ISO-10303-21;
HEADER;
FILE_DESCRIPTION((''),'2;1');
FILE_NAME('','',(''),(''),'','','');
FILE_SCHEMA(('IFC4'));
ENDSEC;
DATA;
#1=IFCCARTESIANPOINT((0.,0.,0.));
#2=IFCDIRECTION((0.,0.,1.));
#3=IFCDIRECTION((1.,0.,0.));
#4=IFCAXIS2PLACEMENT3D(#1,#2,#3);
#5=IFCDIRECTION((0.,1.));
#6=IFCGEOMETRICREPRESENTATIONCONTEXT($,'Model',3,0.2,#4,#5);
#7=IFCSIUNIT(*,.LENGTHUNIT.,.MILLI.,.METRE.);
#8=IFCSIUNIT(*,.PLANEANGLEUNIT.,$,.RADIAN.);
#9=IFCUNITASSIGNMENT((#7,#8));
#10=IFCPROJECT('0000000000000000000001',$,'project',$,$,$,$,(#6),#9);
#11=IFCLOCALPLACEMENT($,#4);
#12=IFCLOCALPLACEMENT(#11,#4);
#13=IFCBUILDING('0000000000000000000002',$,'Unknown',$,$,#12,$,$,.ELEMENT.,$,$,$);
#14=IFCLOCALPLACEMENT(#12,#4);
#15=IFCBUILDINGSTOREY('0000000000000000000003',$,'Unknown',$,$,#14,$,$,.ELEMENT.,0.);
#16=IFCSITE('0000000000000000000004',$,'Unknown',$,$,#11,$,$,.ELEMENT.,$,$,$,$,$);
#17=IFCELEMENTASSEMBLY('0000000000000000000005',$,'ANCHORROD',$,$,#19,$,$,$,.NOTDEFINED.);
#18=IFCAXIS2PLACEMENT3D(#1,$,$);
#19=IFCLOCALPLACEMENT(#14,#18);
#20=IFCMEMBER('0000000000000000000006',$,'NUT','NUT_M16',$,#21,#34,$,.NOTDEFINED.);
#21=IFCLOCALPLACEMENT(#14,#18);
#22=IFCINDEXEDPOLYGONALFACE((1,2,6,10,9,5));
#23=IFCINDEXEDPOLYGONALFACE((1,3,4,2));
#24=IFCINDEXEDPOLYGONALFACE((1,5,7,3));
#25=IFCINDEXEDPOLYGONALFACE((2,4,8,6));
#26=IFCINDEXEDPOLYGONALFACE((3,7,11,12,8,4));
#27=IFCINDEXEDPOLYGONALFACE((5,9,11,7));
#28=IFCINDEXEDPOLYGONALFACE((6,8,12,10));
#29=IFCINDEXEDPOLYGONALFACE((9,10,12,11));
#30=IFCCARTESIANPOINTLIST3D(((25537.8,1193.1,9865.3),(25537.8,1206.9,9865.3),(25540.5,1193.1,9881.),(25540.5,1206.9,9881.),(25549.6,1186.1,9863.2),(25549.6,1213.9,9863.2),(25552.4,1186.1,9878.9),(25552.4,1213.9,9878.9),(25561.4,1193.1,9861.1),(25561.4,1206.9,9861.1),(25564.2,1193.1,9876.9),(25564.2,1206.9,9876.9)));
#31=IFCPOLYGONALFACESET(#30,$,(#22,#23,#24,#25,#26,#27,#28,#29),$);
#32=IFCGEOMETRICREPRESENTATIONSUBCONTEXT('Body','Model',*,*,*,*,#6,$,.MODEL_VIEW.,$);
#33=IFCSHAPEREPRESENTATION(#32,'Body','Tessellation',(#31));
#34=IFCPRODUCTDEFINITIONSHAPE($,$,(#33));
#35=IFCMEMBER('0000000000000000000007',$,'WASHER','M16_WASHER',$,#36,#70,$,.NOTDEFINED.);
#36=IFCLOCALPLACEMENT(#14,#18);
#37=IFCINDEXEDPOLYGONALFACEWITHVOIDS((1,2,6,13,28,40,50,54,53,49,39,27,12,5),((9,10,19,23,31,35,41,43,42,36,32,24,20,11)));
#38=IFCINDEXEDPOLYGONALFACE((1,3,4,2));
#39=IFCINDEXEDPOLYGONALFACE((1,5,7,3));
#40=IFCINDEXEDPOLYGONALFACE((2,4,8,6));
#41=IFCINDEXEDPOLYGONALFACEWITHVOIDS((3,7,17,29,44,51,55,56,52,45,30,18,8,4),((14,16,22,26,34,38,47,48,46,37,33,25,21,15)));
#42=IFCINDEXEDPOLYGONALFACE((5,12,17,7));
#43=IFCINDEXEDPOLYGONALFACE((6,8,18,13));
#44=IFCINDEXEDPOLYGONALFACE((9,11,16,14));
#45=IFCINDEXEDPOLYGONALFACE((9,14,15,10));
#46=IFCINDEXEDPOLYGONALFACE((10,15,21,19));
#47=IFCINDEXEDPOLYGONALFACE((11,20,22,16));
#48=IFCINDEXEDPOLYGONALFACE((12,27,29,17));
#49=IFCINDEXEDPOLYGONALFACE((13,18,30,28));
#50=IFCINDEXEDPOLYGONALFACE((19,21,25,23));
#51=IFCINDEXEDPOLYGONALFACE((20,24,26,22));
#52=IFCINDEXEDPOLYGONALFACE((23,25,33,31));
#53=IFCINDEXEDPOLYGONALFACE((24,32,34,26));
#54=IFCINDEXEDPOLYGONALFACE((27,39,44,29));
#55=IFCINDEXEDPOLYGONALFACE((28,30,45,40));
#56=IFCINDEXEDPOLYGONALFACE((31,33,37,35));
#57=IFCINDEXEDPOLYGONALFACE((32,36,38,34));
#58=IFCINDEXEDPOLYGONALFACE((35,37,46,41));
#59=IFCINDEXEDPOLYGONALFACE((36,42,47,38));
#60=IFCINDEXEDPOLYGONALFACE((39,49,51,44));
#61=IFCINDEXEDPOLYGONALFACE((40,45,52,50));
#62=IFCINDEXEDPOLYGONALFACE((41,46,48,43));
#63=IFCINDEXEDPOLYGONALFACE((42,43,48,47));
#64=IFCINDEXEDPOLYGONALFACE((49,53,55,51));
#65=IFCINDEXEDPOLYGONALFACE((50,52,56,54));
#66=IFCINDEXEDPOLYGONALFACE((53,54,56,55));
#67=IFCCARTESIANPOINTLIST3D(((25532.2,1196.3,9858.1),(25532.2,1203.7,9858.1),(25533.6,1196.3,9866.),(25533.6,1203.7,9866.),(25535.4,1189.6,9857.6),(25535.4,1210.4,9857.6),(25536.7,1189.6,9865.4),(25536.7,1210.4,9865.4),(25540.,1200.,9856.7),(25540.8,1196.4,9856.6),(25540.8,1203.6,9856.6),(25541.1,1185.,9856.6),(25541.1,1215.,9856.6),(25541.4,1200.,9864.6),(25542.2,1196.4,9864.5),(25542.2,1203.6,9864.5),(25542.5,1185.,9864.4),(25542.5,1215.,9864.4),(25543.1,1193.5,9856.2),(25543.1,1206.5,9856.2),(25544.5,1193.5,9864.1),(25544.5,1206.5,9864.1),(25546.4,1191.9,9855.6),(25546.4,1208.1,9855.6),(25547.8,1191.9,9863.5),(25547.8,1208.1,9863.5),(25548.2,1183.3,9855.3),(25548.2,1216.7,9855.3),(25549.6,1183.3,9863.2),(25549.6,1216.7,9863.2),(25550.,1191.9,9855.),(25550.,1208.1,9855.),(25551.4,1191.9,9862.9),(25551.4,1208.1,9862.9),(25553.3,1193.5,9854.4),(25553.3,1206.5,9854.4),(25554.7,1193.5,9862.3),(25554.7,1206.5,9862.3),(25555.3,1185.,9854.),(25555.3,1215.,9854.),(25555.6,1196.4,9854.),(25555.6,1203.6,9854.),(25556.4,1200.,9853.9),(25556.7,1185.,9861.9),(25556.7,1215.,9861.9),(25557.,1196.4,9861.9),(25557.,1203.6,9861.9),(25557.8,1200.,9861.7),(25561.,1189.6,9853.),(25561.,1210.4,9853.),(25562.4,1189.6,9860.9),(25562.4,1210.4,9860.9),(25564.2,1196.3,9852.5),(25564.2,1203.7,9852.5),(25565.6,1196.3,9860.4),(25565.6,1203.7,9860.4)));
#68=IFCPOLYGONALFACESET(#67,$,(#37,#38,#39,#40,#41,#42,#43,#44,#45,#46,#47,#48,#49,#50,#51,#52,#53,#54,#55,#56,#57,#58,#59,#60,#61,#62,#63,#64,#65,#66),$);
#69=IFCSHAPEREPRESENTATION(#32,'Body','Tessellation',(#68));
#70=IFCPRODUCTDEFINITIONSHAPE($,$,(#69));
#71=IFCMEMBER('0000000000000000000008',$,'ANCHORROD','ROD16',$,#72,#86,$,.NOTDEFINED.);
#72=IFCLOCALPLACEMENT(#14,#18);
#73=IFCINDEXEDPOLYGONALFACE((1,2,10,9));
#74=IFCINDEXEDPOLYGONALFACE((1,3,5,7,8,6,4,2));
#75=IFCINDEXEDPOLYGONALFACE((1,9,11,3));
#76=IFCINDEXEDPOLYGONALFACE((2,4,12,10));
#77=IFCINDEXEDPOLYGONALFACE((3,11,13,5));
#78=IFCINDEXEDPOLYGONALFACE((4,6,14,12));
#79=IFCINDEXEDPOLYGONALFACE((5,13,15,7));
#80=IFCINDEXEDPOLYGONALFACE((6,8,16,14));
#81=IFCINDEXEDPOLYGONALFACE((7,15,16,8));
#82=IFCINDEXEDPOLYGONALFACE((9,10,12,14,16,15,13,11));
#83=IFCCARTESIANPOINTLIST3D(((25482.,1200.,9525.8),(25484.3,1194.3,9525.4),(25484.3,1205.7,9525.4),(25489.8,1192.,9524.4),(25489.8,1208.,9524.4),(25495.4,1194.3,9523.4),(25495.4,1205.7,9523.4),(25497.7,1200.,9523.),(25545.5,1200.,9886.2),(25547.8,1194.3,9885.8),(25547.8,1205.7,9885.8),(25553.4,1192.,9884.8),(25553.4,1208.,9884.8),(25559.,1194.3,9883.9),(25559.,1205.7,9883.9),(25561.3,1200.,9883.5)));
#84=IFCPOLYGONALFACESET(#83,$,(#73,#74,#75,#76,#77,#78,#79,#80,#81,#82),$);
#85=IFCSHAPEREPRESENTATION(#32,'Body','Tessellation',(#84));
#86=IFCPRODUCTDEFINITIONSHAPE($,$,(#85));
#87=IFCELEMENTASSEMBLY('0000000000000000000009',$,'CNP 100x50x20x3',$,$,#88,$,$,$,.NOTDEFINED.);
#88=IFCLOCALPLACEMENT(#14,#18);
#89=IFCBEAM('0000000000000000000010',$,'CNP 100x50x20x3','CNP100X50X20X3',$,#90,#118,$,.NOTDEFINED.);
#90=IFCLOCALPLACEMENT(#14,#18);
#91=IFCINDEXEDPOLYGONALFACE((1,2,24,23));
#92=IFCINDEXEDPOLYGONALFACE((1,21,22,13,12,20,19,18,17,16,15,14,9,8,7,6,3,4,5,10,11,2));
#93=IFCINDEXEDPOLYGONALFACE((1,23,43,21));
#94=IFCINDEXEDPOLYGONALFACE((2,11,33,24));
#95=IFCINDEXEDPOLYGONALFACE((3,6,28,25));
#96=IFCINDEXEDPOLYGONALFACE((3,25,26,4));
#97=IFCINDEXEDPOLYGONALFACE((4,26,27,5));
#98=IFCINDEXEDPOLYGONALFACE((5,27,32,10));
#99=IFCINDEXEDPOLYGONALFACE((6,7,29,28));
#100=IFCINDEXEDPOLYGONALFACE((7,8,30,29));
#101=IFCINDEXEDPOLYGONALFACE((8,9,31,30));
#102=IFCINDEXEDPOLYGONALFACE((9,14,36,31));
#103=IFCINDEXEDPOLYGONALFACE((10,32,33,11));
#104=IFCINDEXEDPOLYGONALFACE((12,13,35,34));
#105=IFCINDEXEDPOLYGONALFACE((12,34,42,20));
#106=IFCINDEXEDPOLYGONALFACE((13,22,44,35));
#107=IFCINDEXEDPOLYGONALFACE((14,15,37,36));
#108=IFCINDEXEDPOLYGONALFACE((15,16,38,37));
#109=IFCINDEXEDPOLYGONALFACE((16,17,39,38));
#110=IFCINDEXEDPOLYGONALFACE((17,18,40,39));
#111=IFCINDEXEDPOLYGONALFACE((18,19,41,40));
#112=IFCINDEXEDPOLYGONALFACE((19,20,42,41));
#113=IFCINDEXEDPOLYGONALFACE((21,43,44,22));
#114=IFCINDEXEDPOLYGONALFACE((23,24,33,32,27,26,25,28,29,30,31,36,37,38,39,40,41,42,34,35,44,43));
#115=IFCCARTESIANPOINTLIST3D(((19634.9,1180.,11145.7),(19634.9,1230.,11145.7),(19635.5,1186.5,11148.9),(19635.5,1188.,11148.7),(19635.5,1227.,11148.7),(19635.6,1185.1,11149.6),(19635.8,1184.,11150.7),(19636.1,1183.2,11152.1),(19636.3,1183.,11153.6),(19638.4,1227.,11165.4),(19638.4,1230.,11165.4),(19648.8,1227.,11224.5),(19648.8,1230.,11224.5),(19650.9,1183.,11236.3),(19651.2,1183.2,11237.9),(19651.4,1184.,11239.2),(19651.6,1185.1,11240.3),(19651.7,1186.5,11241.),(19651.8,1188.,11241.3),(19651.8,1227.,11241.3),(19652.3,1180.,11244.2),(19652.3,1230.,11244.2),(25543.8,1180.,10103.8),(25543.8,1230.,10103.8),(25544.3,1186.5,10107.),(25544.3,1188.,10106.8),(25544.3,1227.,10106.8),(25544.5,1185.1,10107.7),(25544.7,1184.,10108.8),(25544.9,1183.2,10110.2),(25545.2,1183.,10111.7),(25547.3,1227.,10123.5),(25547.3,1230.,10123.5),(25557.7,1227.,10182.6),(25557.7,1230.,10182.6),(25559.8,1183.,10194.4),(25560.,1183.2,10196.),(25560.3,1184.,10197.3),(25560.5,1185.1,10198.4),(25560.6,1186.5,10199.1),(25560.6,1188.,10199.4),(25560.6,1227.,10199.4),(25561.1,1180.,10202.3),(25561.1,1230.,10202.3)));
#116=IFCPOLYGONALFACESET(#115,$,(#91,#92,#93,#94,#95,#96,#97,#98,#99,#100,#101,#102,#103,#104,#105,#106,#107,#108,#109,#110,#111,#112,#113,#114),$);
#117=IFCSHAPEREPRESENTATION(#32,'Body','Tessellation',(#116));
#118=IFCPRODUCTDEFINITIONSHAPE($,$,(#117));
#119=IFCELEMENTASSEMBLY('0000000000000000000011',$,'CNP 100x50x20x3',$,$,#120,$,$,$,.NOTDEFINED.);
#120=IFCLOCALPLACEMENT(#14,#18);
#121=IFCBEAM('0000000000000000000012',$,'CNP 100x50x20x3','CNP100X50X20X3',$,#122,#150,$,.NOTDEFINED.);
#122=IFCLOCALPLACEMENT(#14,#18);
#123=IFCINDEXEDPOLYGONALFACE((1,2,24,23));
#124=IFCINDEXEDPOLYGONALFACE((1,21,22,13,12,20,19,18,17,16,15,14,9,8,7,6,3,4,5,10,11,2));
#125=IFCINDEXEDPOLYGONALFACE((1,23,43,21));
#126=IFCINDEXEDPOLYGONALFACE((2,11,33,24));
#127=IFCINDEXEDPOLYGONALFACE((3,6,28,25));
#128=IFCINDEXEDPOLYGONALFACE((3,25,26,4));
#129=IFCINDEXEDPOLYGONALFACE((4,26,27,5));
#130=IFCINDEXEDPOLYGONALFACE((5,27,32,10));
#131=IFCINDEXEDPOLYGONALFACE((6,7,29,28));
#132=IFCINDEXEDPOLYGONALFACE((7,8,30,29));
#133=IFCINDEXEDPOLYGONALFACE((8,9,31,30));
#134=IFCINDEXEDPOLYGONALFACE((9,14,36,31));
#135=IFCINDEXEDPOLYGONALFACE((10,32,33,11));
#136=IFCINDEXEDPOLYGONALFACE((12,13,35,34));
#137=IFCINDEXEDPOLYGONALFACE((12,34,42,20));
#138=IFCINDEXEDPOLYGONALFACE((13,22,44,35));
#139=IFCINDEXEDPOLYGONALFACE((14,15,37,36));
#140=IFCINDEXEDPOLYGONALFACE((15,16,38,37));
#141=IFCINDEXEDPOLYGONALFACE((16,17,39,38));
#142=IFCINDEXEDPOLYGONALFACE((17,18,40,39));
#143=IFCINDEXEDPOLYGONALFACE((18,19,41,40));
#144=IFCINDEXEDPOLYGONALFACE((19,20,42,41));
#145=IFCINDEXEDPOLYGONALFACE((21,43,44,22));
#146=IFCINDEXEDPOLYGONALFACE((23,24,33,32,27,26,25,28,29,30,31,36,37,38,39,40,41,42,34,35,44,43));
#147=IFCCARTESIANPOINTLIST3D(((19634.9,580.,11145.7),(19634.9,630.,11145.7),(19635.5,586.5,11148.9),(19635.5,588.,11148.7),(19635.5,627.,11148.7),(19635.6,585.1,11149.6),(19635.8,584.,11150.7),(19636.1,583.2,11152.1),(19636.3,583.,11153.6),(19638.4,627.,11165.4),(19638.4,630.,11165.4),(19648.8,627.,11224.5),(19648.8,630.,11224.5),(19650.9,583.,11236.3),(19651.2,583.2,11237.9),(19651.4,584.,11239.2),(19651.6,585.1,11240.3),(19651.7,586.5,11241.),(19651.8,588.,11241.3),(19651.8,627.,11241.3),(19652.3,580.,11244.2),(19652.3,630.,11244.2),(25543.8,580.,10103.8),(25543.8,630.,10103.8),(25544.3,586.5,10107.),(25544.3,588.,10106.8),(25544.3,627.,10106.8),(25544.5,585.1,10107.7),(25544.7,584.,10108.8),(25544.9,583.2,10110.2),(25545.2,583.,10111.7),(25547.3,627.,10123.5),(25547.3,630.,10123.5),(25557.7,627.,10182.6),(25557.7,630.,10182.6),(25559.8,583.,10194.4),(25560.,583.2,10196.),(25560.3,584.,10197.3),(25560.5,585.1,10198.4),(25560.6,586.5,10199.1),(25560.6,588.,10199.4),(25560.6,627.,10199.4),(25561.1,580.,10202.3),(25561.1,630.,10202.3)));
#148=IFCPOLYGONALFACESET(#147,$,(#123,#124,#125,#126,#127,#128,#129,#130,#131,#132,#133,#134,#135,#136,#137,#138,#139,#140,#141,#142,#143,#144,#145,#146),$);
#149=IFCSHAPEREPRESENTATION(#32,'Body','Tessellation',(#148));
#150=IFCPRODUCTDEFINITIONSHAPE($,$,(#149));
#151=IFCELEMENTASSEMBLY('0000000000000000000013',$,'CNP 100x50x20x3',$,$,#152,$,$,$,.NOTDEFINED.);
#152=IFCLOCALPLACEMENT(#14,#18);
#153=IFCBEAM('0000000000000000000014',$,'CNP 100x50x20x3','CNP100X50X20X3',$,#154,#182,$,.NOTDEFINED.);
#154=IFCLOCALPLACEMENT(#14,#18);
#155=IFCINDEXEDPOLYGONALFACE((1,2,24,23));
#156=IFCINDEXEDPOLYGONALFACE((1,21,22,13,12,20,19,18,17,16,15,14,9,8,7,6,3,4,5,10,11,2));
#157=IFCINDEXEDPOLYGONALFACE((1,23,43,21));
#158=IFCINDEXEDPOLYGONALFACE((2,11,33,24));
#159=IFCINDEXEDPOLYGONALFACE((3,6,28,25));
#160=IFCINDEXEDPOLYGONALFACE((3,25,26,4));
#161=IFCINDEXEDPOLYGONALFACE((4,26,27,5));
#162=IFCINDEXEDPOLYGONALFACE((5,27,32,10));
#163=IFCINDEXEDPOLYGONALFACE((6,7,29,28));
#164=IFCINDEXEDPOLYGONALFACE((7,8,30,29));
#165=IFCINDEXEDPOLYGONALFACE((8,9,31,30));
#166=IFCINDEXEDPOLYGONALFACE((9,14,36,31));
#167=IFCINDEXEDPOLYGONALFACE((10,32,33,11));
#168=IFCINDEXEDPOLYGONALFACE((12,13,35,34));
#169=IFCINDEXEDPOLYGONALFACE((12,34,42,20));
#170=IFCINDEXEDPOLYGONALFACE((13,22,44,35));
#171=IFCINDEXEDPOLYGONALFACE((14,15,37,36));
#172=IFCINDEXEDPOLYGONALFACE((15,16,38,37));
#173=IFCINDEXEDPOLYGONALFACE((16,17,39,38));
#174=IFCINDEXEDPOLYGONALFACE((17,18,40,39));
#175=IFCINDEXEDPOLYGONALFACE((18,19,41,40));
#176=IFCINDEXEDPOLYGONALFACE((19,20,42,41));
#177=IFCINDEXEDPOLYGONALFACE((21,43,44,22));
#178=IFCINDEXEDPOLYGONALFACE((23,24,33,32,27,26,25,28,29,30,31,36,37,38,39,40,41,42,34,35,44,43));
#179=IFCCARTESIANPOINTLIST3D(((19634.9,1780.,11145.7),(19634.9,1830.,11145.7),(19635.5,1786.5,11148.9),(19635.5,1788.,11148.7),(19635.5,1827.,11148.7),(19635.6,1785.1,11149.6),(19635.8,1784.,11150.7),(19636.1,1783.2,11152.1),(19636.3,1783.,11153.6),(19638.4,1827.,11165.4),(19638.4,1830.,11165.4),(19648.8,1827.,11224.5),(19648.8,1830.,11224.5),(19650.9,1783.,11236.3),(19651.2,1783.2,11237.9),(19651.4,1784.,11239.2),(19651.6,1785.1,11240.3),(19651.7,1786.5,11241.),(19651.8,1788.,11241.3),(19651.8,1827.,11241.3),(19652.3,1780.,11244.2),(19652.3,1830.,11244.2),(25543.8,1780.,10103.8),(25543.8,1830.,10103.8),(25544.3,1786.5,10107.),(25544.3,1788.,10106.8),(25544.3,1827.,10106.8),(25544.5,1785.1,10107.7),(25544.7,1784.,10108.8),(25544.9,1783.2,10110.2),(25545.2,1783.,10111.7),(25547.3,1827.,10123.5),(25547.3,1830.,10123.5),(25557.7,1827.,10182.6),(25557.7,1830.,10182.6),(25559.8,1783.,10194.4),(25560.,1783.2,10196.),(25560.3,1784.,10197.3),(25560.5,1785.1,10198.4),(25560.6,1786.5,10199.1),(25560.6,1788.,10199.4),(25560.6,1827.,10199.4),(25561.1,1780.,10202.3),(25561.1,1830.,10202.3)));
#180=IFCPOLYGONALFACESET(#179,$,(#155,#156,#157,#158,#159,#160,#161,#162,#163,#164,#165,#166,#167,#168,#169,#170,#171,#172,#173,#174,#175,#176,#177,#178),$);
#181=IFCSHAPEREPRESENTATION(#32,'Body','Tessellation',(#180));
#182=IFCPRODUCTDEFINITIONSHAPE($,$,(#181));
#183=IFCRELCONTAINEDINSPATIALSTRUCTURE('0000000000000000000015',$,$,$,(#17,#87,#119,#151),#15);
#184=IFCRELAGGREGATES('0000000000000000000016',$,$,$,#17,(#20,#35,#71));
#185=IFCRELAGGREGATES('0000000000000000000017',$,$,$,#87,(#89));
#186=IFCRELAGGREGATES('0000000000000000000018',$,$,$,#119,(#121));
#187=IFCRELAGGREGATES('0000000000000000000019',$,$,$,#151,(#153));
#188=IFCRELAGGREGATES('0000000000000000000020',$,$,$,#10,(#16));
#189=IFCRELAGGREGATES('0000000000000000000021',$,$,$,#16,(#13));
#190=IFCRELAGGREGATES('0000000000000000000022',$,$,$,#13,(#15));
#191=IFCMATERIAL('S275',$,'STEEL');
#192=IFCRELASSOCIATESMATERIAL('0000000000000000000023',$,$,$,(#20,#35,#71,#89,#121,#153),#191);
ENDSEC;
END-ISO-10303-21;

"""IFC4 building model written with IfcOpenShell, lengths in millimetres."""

from ifc_helpers import new_model, si_unit, direction, frame, origin_with_axes, place, context, subcontext, project, spatial, line, indexed_curve, outline, extrude, material, element, aggregate, save


model = new_model("IFC4")

# Units and contexts
model_context = context("Model", 3, precision=0.2, world=origin_with_axes(), true_north=direction((0.0, 1.0)))
body_context = subcontext(model_context, "Body", "Model", "MODEL_VIEW")
ifc_project = project(units=[si_unit("LENGTHUNIT", "METRE", prefix="MILLI"), si_unit("PLANEANGLEUNIT", "RADIAN")], contexts=[model_context])

# Site, building, storey
site_placement = place(None, origin_with_axes())
site = spatial("IfcSite", under=ifc_project, at=site_placement, Name="Unknown", CompositionType="ELEMENT")
building_placement = place(site_placement, origin_with_axes())
building = spatial("IfcBuilding", under=site, at=building_placement, Name="Unknown", CompositionType="ELEMENT")
storey_placement = place(building_placement, origin_with_axes())
storey = spatial("IfcBuildingStorey", under=building, at=storey_placement, Name="Unknown", CompositionType="ELEMENT", Elevation=0.0)

# Element assembly, members
assembly_1_placement = place(storey_placement, frame((25553.4, 1200.0, 9884.8), z_axis=(0.0, -1.0, 0.0), x_axis=(-0.173648, 0.0, -0.984808)))
assembly_1 = element("IfcElementAssembly", 1, at=assembly_1_placement, inside=storey, Name="ANCHORROD", PredefinedType="NOTDEFINED")
ifc_material_1 = material(Name="S275", Category="STEEL")
member_1_placement = place(assembly_1_placement, frame((6.0, 0.0, 0.0), z_axis=(0.0, 0.0, 1.0), x_axis=(1.0, 0.0, 0.0)))
member_1 = element("IfcMember", 2, at=member_1_placement, material=ifc_material_1, Name="NUT", Description="NUT_M16", PredefinedType="NOTDEFINED", context=body_context, shape_type="SolidModel", body=[
    extrude(outline(indexed_curve([(6.9, -12.0), (13.9, 0.0), (6.9, 12.0), (-6.9, 12.0), (-13.9, 0.0), (-6.9, -12.0)], segments=[line(1, 2, 3, 4, 5, 6, 1)])), frame((0.0, 0.0, 0.0), z_axis=(-1.0, 0.0, 0.0), x_axis=(0.0, 0.0, 1.0)), (0.0, 0.0, -1.0), 16.0),
])
member_2_placement = place(assembly_1_placement, frame((22.0, 0.0, 0.0), z_axis=(0.0, 0.0, 1.0), x_axis=(1.0, 0.0, 0.0)))
member_2 = element("IfcMember", 3, at=member_2_placement, material=ifc_material_1, Name="WASHER", Description="M16_WASHER", PredefinedType="NOTDEFINED", context=body_context, shape_type="SolidModel", body=[
    extrude(outline(indexed_curve([(16.7, 0.0), (15.0, 7.2), (10.4, 13.0), (3.7, 16.3), (-3.7, 16.3), (-10.4, 13.0), (-15.0, 7.2), (-16.7, 0.0), (-15.0, -7.2), (-10.4, -13.0), (-3.7, -16.3), (3.7, -16.3), (10.4, -13.0), (15.0, -7.2)], segments=[line(1, 2, 3, 4, 5, 6, 7, 8, 9, 10, 11, 12, 13, 14, 1)]), holes=[indexed_curve([(0.0, 8.3), (3.6, 7.5), (6.5, 5.2), (8.1, 1.9), (8.1, -1.9), (6.5, -5.2), (3.6, -7.5), (0.0, -8.3), (-3.6, -7.5), (-6.5, -5.2), (-8.1, -1.9), (-8.1, 1.9), (-6.5, 5.2), (-3.6, 7.5)], segments=[line(1, 2, 3, 4, 5, 6, 7, 8, 9, 10, 11, 12, 13, 14, 1)])]), frame((0.0, 0.0, 0.0), z_axis=(-1.0, 0.0, 0.0), x_axis=(0.0, 0.0, 1.0)), (0.0, 0.0, -1.0), 8.0),
])
member_3_placement = place(assembly_1_placement, origin_with_axes())
member_3 = element("IfcMember", 4, at=member_3_placement, material=ifc_material_1, Name="ANCHORROD", Description="ROD16", PredefinedType="NOTDEFINED", context=body_context, shape_type="SolidModel", body=[
    extrude(outline(indexed_curve([(8.0, 0.0), (5.7, 5.7), (0.0, 8.0), (-5.7, 5.7), (-8.0, 0.0), (-5.7, -5.7), (0.0, -8.0), (5.7, -5.7)], segments=[line(1, 2, 3, 4, 5, 6, 7, 8, 1)])), frame((0.0, 0.0, 0.0), z_axis=(-1.0, 0.0, 0.0), x_axis=(0.0, 0.0, 1.0)), (0.0, 0.0, -1.0), 366.0),
])
aggregate(assembly_1, [member_1, member_2, member_3])

# Element assemblies, beams
assembly_2_placement = place(storey_placement, frame((25552.5, 1205.0, 10153.1), z_axis=(0.173648, 0.0, 0.984808), x_axis=(-0.984808, 0.0, 0.173648)))
assembly_2 = element("IfcElementAssembly", 5, at=assembly_2_placement, inside=storey, Name="CNP 100x50x20x3", PredefinedType="NOTDEFINED")
beam_1_placement = place(assembly_2_placement, origin_with_axes())
beam_1 = element("IfcBeam", 6, at=beam_1_placement, material=ifc_material_1, Name="CNP 100x50x20x3", Description="CNP100X50X20X3", PredefinedType="NOTDEFINED", context=body_context, shape_type="SolidModel", body=[
    extrude(outline(indexed_curve([(50.0, -25.0), (50.0, 25.0), (-50.0, 25.0), (-50.0, -25.0), (-30.0, -25.0), (-30.0, -22.0), (-47.0, -22.0), (-47.0, 17.0), (-46.8, 18.5), (-46.0, 19.9), (-44.9, 21.0), (-43.5, 21.8), (-42.0, 22.0), (42.0, 22.0), (43.5, 21.8), (44.9, 21.0), (46.0, 19.9), (46.8, 18.5), (47.0, 17.0), (47.0, -22.0), (30.0, -22.0), (30.0, -25.0)], segments=[line(1, 2, 3, 4, 5, 6, 7, 8, 9, 10, 11, 12, 13, 14, 15, 16, 17, 18, 19, 20, 21, 22, 1)])), frame((0.0, 0.0, 0.0), z_axis=(-1.0, 0.0, 0.0), x_axis=(0.0, 0.0, 1.0)), (0.0, 0.0, -1.0), 6000.0),
])
aggregate(assembly_2, [beam_1])
assembly_3_placement = place(storey_placement, frame((25552.5, 605.0, 10153.1), z_axis=(0.173648, 0.0, 0.984808), x_axis=(-0.984808, 0.0, 0.173648)))
assembly_3 = element("IfcElementAssembly", 7, at=assembly_3_placement, inside=storey, Name="CNP 100x50x20x3", PredefinedType="NOTDEFINED")
beam_2_placement = place(assembly_3_placement, origin_with_axes())
beam_2 = element("IfcBeam", 8, at=beam_2_placement, material=ifc_material_1, Name="CNP 100x50x20x3", Description="CNP100X50X20X3", PredefinedType="NOTDEFINED", context=body_context, shape_type="SolidModel", body=[
    extrude(outline(indexed_curve([(50.0, -25.0), (50.0, 25.0), (-50.0, 25.0), (-50.0, -25.0), (-30.0, -25.0), (-30.0, -22.0), (-47.0, -22.0), (-47.0, 17.0), (-46.8, 18.5), (-46.0, 19.9), (-44.9, 21.0), (-43.5, 21.8), (-42.0, 22.0), (42.0, 22.0), (43.5, 21.8), (44.9, 21.0), (46.0, 19.9), (46.8, 18.5), (47.0, 17.0), (47.0, -22.0), (30.0, -22.0), (30.0, -25.0)], segments=[line(1, 2, 3, 4, 5, 6, 7, 8, 9, 10, 11, 12, 13, 14, 15, 16, 17, 18, 19, 20, 21, 22, 1)])), frame((0.0, 0.0, 0.0), z_axis=(-1.0, 0.0, 0.0), x_axis=(0.0, 0.0, 1.0)), (0.0, 0.0, -1.0), 6000.0),
])
aggregate(assembly_3, [beam_2])
assembly_4_placement = place(storey_placement, frame((25552.5, 1805.0, 10153.1), z_axis=(0.173648, 0.0, 0.984808), x_axis=(-0.984808, 0.0, 0.173648)))
assembly_4 = element("IfcElementAssembly", 9, at=assembly_4_placement, inside=storey, Name="CNP 100x50x20x3", PredefinedType="NOTDEFINED")
beam_3_placement = place(assembly_4_placement, origin_with_axes())
beam_3 = element("IfcBeam", 10, at=beam_3_placement, material=ifc_material_1, Name="CNP 100x50x20x3", Description="CNP100X50X20X3", PredefinedType="NOTDEFINED", context=body_context, shape_type="SolidModel", body=[
    extrude(outline(indexed_curve([(50.0, -25.0), (50.0, 25.0), (-50.0, 25.0), (-50.0, -25.0), (-30.0, -25.0), (-30.0, -22.0), (-47.0, -22.0), (-47.0, 17.0), (-46.8, 18.5), (-46.0, 19.9), (-44.9, 21.0), (-43.5, 21.8), (-42.0, 22.0), (42.0, 22.0), (43.5, 21.8), (44.9, 21.0), (46.0, 19.9), (46.8, 18.5), (47.0, 17.0), (47.0, -22.0), (30.0, -22.0), (30.0, -25.0)], segments=[line(1, 2, 3, 4, 5, 6, 7, 8, 9, 10, 11, 12, 13, 14, 15, 16, 17, 18, 19, 20, 21, 22, 1)])), frame((0.0, 0.0, 0.0), z_axis=(-1.0, 0.0, 0.0), x_axis=(0.0, 0.0, 1.0)), (0.0, 0.0, -1.0), 6000.0),
])
aggregate(assembly_4, [beam_3])

save(model, "model.ifc")
